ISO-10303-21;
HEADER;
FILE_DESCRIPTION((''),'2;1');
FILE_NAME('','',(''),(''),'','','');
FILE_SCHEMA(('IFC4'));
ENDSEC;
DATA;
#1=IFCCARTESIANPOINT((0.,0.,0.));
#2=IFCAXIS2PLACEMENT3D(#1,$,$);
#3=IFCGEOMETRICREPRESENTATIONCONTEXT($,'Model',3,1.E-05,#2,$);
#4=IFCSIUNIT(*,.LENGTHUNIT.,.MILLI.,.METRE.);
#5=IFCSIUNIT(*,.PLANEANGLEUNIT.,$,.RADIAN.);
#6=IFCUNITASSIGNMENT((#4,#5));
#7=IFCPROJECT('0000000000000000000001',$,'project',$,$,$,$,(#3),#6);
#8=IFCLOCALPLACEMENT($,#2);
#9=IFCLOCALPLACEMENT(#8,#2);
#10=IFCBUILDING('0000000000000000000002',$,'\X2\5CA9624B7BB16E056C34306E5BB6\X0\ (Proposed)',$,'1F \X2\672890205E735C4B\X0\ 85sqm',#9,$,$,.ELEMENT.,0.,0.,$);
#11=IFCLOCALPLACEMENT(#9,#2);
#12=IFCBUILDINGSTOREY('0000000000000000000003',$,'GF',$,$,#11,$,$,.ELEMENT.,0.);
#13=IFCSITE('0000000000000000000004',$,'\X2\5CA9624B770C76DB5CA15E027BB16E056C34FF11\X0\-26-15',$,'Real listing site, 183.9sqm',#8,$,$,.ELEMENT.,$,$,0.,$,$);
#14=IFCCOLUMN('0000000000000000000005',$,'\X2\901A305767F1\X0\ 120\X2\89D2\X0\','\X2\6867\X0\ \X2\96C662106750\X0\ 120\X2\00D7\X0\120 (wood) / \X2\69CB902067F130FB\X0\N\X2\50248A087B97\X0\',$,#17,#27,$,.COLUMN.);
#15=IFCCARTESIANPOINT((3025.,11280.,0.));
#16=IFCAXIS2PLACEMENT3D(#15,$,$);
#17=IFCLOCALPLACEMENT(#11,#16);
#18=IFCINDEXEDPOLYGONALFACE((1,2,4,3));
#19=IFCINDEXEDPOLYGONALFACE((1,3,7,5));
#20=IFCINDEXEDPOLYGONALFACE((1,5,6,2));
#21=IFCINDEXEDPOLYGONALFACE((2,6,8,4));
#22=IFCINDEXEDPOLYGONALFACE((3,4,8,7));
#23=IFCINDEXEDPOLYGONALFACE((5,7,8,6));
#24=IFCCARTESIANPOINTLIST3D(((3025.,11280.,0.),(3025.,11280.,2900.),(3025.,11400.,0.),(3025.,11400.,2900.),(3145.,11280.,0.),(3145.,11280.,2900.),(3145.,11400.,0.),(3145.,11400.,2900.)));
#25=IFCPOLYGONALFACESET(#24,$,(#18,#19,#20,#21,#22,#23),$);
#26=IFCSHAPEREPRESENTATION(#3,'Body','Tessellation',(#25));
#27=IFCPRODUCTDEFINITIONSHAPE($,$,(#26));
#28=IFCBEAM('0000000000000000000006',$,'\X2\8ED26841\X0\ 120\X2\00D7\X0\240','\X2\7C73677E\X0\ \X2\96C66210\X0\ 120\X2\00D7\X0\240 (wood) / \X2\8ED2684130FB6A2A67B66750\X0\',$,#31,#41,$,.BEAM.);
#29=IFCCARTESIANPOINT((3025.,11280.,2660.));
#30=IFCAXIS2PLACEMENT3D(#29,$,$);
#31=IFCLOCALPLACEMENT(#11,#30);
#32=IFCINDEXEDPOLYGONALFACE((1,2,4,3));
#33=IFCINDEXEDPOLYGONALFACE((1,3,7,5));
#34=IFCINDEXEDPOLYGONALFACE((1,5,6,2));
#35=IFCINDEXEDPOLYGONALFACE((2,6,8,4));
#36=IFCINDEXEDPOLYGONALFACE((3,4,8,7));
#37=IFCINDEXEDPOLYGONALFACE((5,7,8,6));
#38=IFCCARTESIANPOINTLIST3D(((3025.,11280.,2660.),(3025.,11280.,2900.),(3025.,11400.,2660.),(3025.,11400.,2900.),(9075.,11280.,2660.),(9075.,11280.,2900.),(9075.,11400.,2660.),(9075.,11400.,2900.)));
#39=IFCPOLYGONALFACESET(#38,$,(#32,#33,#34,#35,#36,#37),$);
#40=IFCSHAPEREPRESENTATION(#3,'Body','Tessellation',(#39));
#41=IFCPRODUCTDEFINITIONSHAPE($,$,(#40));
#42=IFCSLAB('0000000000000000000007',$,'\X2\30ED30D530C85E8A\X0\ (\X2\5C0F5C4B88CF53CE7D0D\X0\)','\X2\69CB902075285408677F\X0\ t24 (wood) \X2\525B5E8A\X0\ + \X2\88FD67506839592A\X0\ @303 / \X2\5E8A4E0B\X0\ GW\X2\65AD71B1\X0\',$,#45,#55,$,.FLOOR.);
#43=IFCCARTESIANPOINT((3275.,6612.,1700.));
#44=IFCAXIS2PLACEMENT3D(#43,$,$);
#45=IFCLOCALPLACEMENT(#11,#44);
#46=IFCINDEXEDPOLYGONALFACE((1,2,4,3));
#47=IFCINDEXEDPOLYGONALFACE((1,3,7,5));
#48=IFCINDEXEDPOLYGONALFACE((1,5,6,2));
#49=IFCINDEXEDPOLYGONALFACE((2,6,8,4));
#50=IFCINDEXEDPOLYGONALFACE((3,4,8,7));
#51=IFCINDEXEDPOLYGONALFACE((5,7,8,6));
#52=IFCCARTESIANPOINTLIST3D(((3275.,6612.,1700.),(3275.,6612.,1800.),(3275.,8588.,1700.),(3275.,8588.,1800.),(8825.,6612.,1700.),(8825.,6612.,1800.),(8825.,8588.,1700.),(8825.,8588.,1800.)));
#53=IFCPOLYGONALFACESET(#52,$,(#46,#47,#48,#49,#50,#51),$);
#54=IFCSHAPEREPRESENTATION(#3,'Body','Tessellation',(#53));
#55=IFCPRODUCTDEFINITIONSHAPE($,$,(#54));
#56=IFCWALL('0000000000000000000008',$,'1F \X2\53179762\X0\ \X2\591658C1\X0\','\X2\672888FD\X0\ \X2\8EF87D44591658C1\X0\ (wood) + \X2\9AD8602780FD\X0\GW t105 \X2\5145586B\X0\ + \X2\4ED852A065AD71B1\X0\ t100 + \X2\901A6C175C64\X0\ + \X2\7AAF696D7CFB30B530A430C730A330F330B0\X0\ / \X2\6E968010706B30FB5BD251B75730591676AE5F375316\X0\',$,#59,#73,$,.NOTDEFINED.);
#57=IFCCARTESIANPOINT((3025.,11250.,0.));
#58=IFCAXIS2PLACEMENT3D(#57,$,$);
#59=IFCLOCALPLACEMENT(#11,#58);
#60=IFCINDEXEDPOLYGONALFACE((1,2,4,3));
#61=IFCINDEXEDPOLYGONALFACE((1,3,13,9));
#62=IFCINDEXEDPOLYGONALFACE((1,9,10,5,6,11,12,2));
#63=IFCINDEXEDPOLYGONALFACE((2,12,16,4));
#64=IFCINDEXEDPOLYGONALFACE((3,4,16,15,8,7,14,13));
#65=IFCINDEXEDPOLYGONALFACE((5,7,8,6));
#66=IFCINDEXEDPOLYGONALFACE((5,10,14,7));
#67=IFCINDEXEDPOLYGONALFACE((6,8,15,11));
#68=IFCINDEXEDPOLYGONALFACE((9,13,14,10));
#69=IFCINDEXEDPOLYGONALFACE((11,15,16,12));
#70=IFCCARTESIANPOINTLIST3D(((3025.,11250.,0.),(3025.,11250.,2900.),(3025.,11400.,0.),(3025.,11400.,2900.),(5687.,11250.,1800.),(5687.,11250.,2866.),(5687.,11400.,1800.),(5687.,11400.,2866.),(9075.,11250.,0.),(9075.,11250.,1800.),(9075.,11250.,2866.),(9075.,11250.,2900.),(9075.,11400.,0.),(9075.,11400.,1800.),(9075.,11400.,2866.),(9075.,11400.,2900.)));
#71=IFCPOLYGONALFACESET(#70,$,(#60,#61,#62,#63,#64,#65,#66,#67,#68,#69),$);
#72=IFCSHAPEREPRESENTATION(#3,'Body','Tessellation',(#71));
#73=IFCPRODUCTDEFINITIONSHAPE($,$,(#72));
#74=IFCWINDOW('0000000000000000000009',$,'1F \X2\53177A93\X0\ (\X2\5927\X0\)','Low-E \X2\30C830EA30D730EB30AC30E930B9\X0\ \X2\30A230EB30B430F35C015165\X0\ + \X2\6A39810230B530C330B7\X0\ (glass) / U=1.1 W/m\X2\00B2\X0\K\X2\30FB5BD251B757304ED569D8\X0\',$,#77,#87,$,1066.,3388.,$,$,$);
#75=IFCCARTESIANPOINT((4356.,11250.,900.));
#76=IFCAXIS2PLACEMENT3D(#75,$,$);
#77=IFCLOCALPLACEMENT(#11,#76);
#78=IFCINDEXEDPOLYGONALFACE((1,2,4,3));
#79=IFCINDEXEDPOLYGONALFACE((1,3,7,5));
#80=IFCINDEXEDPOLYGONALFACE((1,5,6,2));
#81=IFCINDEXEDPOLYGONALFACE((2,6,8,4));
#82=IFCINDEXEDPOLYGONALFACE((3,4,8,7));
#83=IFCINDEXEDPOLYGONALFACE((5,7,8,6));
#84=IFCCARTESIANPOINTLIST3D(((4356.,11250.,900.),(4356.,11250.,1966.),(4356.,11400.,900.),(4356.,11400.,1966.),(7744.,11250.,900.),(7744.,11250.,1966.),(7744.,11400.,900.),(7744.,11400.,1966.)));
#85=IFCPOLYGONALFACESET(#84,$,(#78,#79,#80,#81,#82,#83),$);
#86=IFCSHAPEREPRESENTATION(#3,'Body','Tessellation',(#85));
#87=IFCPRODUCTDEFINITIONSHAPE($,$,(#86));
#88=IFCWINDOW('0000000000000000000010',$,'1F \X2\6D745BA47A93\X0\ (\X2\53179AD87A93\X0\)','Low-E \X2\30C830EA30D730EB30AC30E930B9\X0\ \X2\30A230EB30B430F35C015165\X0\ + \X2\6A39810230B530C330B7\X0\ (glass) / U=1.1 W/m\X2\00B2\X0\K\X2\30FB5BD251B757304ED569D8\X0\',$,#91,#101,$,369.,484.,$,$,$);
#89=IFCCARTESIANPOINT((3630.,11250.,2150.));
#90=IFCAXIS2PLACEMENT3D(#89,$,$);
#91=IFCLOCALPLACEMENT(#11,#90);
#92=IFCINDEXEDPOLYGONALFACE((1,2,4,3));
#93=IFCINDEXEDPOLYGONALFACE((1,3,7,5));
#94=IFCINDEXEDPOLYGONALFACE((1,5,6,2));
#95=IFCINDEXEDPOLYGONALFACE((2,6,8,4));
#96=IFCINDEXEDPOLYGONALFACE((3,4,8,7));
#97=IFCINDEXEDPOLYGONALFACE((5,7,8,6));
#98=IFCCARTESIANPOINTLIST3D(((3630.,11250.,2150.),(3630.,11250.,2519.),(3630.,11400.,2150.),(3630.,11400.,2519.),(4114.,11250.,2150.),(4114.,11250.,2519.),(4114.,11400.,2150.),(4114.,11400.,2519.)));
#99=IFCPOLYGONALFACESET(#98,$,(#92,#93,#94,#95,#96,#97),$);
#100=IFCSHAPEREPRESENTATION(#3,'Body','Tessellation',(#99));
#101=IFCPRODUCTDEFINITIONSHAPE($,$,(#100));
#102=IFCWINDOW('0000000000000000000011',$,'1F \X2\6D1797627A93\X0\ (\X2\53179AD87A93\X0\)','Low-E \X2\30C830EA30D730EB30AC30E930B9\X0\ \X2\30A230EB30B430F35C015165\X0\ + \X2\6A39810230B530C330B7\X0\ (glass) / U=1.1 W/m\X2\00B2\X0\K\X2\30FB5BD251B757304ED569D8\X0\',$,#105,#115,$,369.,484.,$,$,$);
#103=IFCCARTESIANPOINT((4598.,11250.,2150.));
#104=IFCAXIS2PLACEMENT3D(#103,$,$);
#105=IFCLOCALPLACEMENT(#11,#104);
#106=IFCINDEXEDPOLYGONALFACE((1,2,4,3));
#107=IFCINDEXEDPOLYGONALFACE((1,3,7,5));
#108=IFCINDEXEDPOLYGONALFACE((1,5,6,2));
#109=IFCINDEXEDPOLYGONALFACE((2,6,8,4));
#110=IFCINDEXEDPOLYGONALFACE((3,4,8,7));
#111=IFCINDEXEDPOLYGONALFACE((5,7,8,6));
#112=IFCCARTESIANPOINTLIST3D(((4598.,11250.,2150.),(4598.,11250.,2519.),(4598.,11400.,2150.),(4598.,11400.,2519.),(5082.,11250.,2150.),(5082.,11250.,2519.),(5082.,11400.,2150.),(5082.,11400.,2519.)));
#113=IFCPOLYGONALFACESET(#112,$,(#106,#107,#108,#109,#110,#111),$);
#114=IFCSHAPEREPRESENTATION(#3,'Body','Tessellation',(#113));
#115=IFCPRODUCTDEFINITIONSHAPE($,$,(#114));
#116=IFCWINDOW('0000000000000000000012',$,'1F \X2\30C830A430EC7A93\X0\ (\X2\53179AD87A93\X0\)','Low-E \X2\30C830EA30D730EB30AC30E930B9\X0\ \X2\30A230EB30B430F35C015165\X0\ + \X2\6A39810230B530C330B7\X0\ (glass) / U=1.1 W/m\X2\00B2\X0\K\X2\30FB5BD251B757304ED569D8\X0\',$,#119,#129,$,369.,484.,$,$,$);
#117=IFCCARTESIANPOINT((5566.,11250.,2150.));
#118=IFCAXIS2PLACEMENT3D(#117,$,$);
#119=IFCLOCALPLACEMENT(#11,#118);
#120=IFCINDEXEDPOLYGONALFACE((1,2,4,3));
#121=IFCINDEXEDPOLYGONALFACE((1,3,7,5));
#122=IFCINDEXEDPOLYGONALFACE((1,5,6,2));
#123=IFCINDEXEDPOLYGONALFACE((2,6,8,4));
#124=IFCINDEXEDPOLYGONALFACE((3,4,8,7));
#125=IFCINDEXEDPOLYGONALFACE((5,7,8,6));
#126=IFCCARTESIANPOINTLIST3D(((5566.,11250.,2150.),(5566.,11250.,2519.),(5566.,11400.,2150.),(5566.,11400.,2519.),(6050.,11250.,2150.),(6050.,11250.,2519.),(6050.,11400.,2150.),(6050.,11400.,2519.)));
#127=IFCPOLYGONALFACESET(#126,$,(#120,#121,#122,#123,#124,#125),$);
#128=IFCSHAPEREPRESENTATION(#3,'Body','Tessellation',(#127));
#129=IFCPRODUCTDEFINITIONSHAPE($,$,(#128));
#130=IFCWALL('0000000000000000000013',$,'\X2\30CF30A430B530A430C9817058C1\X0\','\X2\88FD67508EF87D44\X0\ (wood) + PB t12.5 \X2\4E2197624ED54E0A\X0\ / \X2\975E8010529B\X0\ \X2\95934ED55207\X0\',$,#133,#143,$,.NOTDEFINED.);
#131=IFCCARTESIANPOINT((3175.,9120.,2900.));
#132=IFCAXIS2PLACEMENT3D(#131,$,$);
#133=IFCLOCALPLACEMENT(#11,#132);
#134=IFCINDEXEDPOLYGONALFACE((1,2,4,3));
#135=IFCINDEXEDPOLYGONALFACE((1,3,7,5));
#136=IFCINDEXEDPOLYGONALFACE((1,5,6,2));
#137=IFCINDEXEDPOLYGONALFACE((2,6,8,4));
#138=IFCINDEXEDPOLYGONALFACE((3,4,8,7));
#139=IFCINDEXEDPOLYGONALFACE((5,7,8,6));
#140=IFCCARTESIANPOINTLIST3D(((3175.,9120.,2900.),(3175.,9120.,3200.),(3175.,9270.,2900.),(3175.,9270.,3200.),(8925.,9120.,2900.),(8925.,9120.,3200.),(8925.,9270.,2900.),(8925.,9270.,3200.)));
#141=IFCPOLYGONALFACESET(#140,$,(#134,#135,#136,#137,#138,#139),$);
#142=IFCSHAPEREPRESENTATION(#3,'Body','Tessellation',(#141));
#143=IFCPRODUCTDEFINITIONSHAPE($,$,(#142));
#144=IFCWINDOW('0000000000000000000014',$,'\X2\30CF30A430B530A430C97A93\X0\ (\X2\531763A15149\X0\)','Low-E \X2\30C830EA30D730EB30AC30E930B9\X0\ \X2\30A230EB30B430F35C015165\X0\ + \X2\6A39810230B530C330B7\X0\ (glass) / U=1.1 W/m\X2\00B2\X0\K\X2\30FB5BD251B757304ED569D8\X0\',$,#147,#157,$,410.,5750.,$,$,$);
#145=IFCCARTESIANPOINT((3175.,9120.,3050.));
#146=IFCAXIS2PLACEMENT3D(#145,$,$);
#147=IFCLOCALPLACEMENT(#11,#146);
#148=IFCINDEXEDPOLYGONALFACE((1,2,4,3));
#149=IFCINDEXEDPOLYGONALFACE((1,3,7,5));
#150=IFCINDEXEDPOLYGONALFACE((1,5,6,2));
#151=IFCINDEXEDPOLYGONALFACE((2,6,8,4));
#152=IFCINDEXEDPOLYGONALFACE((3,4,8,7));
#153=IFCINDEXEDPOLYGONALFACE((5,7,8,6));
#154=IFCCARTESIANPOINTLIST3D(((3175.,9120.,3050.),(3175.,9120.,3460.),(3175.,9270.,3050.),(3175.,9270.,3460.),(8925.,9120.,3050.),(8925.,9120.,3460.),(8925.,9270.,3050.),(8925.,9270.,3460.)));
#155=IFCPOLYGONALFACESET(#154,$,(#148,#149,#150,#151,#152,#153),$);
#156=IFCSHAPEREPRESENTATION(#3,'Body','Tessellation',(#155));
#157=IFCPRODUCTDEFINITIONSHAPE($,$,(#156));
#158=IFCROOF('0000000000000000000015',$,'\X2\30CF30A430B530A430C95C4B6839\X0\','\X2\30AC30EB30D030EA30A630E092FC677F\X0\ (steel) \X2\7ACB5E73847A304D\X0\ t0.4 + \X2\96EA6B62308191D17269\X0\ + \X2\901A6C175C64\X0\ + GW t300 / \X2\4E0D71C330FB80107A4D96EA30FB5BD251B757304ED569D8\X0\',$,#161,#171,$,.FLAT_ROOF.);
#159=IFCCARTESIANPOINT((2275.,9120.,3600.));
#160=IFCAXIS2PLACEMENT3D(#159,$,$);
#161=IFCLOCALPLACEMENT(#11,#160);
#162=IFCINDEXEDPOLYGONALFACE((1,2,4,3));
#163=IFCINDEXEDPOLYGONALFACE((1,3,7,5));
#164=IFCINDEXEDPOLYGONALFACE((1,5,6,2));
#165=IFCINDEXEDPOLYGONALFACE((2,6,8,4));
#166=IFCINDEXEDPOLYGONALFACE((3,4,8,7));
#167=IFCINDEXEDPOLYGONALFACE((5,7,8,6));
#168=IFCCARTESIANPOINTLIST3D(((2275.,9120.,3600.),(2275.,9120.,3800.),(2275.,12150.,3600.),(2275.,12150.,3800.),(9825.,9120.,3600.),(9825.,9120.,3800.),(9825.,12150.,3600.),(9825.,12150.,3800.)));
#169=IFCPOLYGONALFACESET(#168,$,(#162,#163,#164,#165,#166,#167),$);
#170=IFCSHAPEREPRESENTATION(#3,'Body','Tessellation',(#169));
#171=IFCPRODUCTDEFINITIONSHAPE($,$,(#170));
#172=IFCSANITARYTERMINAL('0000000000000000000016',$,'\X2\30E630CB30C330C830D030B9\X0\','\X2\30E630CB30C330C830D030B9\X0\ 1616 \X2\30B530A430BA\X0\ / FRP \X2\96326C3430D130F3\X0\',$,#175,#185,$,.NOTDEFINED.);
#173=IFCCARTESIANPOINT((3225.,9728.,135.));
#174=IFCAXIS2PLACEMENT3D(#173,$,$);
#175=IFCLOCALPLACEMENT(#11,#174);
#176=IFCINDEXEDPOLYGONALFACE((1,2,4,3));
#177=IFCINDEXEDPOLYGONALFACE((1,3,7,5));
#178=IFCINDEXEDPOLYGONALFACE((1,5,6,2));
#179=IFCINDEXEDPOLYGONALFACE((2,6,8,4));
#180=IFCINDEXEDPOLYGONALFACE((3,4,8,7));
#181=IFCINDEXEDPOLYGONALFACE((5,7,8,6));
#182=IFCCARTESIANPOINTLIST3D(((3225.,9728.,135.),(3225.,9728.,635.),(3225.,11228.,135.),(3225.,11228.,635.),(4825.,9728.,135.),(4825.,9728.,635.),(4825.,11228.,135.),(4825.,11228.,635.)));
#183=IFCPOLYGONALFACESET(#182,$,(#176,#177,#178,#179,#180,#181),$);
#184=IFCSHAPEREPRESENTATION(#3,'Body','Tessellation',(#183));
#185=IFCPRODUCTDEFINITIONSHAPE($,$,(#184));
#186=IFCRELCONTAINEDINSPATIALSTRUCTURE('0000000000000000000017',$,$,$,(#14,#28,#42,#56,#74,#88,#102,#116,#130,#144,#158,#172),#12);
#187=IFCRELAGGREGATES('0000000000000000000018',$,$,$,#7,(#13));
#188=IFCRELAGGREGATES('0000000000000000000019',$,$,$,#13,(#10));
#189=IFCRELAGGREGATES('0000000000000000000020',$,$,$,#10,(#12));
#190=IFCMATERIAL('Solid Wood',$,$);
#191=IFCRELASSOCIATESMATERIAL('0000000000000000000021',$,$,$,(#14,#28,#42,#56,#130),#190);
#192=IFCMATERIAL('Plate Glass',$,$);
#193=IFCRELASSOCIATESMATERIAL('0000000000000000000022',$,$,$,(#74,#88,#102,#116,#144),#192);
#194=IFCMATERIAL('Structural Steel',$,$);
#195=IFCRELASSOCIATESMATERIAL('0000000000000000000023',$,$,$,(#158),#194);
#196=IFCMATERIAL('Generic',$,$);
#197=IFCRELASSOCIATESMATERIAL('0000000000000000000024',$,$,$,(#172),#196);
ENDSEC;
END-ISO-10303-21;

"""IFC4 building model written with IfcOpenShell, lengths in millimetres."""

from ifc_helpers import new_model, si_unit, frame, frame_2d, origin, place, context, project, spatial, rectangle, extrude, material, element, fill, save


model = new_model("IFC4")

# Units and contexts
model_context = context("Model", 3, precision=1e-05, world=origin())
ifc_project = project(units=[si_unit("LENGTHUNIT", "METRE", prefix="MILLI"), si_unit("PLANEANGLEUNIT", "RADIAN")], contexts=[model_context])

# Site, building, storey
site_placement = place(None, origin())
site = spatial("IfcSite", under=ifc_project, at=site_placement, Name="岩手県盛岡市箱清水１-26-15", ObjectType="Real listing site, 183.9sqm", CompositionType="ELEMENT", RefElevation=0.0)
building_placement = place(site_placement, origin())
building = spatial("IfcBuilding", under=site, at=building_placement, Name="岩手箱清水の家 (Proposed)", ObjectType="1F 木造平屋 85sqm", CompositionType="ELEMENT", ElevationOfRefHeight=0.0, ElevationOfTerrain=0.0)
storey_placement = place(building_placement, origin())
storey = spatial("IfcBuildingStorey", under=building, at=storey_placement, Name="GF", CompositionType="ELEMENT", Elevation=0.0)

# Column
ifc_material_1 = material(Name="Solid Wood")
column_1_placement = place(storey_placement, frame((3025.0, 11280.0, 0.0)))
element("IfcColumn", 1, at=column_1_placement, inside=storey, material=ifc_material_1, Name="通し柱 120角", Description="桧 集成材 120×120 (wood) / 構造柱・N値計算", PredefinedType="COLUMN", context=model_context, shape_type="SweptSolid", body=[
    extrude(rectangle(XDim=120.0, YDim=120.0, at=frame_2d((60.0, 60.0))), frame((3025.0, 11280.0, 0.0)), (0.0, 0.0, 1.0), 2900.0),
])

# Beam
beam_1_placement = place(storey_placement, frame((3025.0, 11280.0, 2660.0)))
element("IfcBeam", 2, at=beam_1_placement, inside=storey, material=ifc_material_1, Name="軒桁 120×240", Description="米松 集成 120×240 (wood) / 軒桁・横架材", PredefinedType="BEAM", context=model_context, shape_type="SweptSolid", body=[
    extrude(rectangle(XDim=6050.0, YDim=120.0, at=frame_2d((3025.0, 60.0))), frame((3025.0, 11280.0, 2660.0)), (0.0, 0.0, 1.0), 240.0),
])

# Slab
slab_placement = place(storey_placement, frame((3275.0, 6612.0, 1700.0)))
element("IfcSlab", 3, at=slab_placement, inside=storey, material=ifc_material_1, Name="ロフト床 (小屋裏収納)", Description="構造用合板 t24 (wood) 剛床 + 製材根太 @303 / 床下 GW断熱", PredefinedType="FLOOR", context=model_context, shape_type="SweptSolid", body=[
    extrude(rectangle(XDim=5550.0, YDim=1976.0, at=frame_2d((2775.0, 988.0))), frame((3275.0, 6612.0, 1700.0)), (0.0, 0.0, 1.0), 100.0),
])

# Wall, openings, windows
wall_1_placement = place(storey_placement, frame((3025.0, 11250.0, 0.0)))
wall_1 = element("IfcWall", 4, at=wall_1_placement, inside=storey, material=ifc_material_1, Name="1F 北面 外壁", Description="木製 軸組外壁 (wood) + 高性能GW t105 充填 + 付加断熱 t100 + 通気層 + 窯業系サイディング / 準耐火・寒冷地外皮強化", PredefinedType="NOTDEFINED", context=model_context, shape_type="SweptSolid", body=[
    extrude(rectangle(XDim=6050.0, YDim=150.0, at=frame_2d((3025.0, 75.0))), frame((3025.0, 11250.0, 0.0)), (0.0, 0.0, 1.0), 2900.0),
])
opening_1_placement = place(storey_placement, frame((4356.0, 11250.0, 900.0)))
opening_1 = element("IfcOpeningElement", 5, at=opening_1_placement, cuts=wall_1, PredefinedType="NOTDEFINED", context=model_context, shape_type="SweptSolid", body=[
    extrude(rectangle(XDim=3388.0, YDim=150.0, at=frame_2d((1694.0, 75.0))), frame((4356.0, 11250.0, 900.0)), (0.0, 0.0, 1.0), 1066.0),
])
opening_2_placement = place(storey_placement, frame((3630.0, 11250.0, 2150.0)))
opening_2 = element("IfcOpeningElement", 6, at=opening_2_placement, cuts=wall_1, PredefinedType="NOTDEFINED", context=model_context, shape_type="SweptSolid", body=[
    extrude(rectangle(XDim=484.0, YDim=150.0, at=frame_2d((242.0, 75.0))), frame((3630.0, 11250.0, 2150.0)), (0.0, 0.0, 1.0), 369.0),
])
opening_3_placement = place(storey_placement, frame((4598.0, 11250.0, 2150.0)))
opening_3 = element("IfcOpeningElement", 7, at=opening_3_placement, cuts=wall_1, PredefinedType="NOTDEFINED", context=model_context, shape_type="SweptSolid", body=[
    extrude(rectangle(XDim=484.0, YDim=150.0, at=frame_2d((242.0, 75.0))), frame((4598.0, 11250.0, 2150.0)), (0.0, 0.0, 1.0), 369.0),
])
opening_4_placement = place(storey_placement, frame((5566.0, 11250.0, 2150.0)))
opening_4 = element("IfcOpeningElement", 8, at=opening_4_placement, cuts=wall_1, PredefinedType="NOTDEFINED", context=model_context, shape_type="SweptSolid", body=[
    extrude(rectangle(XDim=484.0, YDim=150.0, at=frame_2d((242.0, 75.0))), frame((5566.0, 11250.0, 2150.0)), (0.0, 0.0, 1.0), 369.0),
])
ifc_material_2 = material(Name="Plate Glass")
window_1_placement = place(storey_placement, frame((4356.0, 11250.0, 900.0)))
window_1 = element("IfcWindow", 9, at=window_1_placement, inside=storey, material=ifc_material_2, Name="1F 北窓 (大)", Description="Low-E トリプルガラス アルゴン封入 + 樹脂サッシ (glass) / U=1.1 W/m²K・寒冷地仕様", OverallHeight=1066.0, OverallWidth=3388.0, context=model_context, shape_type="SweptSolid", body=[
    extrude(rectangle(XDim=3388.0, YDim=150.0, at=frame_2d((1694.0, 75.0))), frame((4356.0, 11250.0, 900.0)), (0.0, 0.0, 1.0), 1066.0),
])
fill(opening_1, window_1)
window_2_placement = place(storey_placement, frame((3630.0, 11250.0, 2150.0)))
window_2 = element("IfcWindow", 10, at=window_2_placement, inside=storey, material=ifc_material_2, Name="1F 浴室窓 (北高窓)", Description="Low-E トリプルガラス アルゴン封入 + 樹脂サッシ (glass) / U=1.1 W/m²K・寒冷地仕様", OverallHeight=369.0, OverallWidth=484.0, context=model_context, shape_type="SweptSolid", body=[
    extrude(rectangle(XDim=484.0, YDim=150.0, at=frame_2d((242.0, 75.0))), frame((3630.0, 11250.0, 2150.0)), (0.0, 0.0, 1.0), 369.0),
])
fill(opening_2, window_2)
window_3_placement = place(storey_placement, frame((4598.0, 11250.0, 2150.0)))
window_3 = element("IfcWindow", 11, at=window_3_placement, inside=storey, material=ifc_material_2, Name="1F 洗面窓 (北高窓)", Description="Low-E トリプルガラス アルゴン封入 + 樹脂サッシ (glass) / U=1.1 W/m²K・寒冷地仕様", OverallHeight=369.0, OverallWidth=484.0, context=model_context, shape_type="SweptSolid", body=[
    extrude(rectangle(XDim=484.0, YDim=150.0, at=frame_2d((242.0, 75.0))), frame((4598.0, 11250.0, 2150.0)), (0.0, 0.0, 1.0), 369.0),
])
fill(opening_3, window_3)
window_4_placement = place(storey_placement, frame((5566.0, 11250.0, 2150.0)))
window_4 = element("IfcWindow", 12, at=window_4_placement, inside=storey, material=ifc_material_2, Name="1F トイレ窓 (北高窓)", Description="Low-E トリプルガラス アルゴン封入 + 樹脂サッシ (glass) / U=1.1 W/m²K・寒冷地仕様", OverallHeight=369.0, OverallWidth=484.0, context=model_context, shape_type="SweptSolid", body=[
    extrude(rectangle(XDim=484.0, YDim=150.0, at=frame_2d((242.0, 75.0))), frame((5566.0, 11250.0, 2150.0)), (0.0, 0.0, 1.0), 369.0),
])
fill(opening_4, window_4)

# Wall, opening, window
wall_2_placement = place(storey_placement, frame((3175.0, 9120.0, 2900.0)))
wall_2 = element("IfcWall", 13, at=wall_2_placement, inside=storey, material=ifc_material_1, Name="ハイサイド腰壁", Description="製材軸組 (wood) + PB t12.5 両面仕上 / 非耐力 間仕切", PredefinedType="NOTDEFINED", context=model_context, shape_type="SweptSolid", body=[
    extrude(rectangle(XDim=5750.0, YDim=150.0, at=frame_2d((2875.0, 75.0))), frame((3175.0, 9120.0, 2900.0)), (0.0, 0.0, 1.0), 700.0),
])
opening_5_placement = place(storey_placement, frame((3175.0, 9120.0, 3050.0)))
opening_5 = element("IfcOpeningElement", 14, at=opening_5_placement, cuts=wall_2, PredefinedType="NOTDEFINED", context=model_context, shape_type="SweptSolid", body=[
    extrude(rectangle(XDim=5750.0, YDim=150.0, at=frame_2d((2875.0, 75.0))), frame((3175.0, 9120.0, 3050.0)), (0.0, 0.0, 1.0), 410.0),
])
window_5_placement = place(storey_placement, frame((3175.0, 9120.0, 3050.0)))
window_5 = element("IfcWindow", 15, at=window_5_placement, inside=storey, material=ifc_material_2, Name="ハイサイド窓 (北採光)", Description="Low-E トリプルガラス アルゴン封入 + 樹脂サッシ (glass) / U=1.1 W/m²K・寒冷地仕様", OverallHeight=410.0, OverallWidth=5750.0, context=model_context, shape_type="SweptSolid", body=[
    extrude(rectangle(XDim=5750.0, YDim=150.0, at=frame_2d((2875.0, 75.0))), frame((3175.0, 9120.0, 3050.0)), (0.0, 0.0, 1.0), 410.0),
])
fill(opening_5, window_5)

# Roof
ifc_material_3 = material(Name="Structural Steel")
roof_placement = place(storey_placement, frame((2275.0, 9120.0, 3600.0)))
element("IfcRoof", 16, at=roof_placement, inside=storey, material=ifc_material_3, Name="ハイサイド屋根", Description="ガルバリウム鋼板 (steel) 立平葺き t0.4 + 雪止め金物 + 通気層 + GW t300 / 不燃・耐積雪・寒冷地仕様", PredefinedType="FLAT_ROOF", context=model_context, shape_type="SweptSolid", body=[
    extrude(rectangle(XDim=7550.0, YDim=3030.0, at=frame_2d((3775.0, 1515.0))), frame((2275.0, 9120.0, 3600.0)), (0.0, 0.0, 1.0), 200.0),
])

# Sanitary terminal
ifc_material_4 = material(Name="Generic")
sanitary_terminal_placement = place(storey_placement, frame((3225.0, 9728.0, 135.0)))
element("IfcSanitaryTerminal", 17, at=sanitary_terminal_placement, inside=storey, material=ifc_material_4, Name="ユニットバス", Description="ユニットバス 1616 サイズ / FRP 防水パン", PredefinedType="NOTDEFINED", context=model_context, shape_type="SweptSolid", body=[
    extrude(rectangle(XDim=1600.0, YDim=1500.0, at=frame_2d((800.0, 750.0))), frame((3225.0, 9728.0, 135.0)), (0.0, 0.0, 1.0), 500.0),
])

save(model, "model.ifc")
